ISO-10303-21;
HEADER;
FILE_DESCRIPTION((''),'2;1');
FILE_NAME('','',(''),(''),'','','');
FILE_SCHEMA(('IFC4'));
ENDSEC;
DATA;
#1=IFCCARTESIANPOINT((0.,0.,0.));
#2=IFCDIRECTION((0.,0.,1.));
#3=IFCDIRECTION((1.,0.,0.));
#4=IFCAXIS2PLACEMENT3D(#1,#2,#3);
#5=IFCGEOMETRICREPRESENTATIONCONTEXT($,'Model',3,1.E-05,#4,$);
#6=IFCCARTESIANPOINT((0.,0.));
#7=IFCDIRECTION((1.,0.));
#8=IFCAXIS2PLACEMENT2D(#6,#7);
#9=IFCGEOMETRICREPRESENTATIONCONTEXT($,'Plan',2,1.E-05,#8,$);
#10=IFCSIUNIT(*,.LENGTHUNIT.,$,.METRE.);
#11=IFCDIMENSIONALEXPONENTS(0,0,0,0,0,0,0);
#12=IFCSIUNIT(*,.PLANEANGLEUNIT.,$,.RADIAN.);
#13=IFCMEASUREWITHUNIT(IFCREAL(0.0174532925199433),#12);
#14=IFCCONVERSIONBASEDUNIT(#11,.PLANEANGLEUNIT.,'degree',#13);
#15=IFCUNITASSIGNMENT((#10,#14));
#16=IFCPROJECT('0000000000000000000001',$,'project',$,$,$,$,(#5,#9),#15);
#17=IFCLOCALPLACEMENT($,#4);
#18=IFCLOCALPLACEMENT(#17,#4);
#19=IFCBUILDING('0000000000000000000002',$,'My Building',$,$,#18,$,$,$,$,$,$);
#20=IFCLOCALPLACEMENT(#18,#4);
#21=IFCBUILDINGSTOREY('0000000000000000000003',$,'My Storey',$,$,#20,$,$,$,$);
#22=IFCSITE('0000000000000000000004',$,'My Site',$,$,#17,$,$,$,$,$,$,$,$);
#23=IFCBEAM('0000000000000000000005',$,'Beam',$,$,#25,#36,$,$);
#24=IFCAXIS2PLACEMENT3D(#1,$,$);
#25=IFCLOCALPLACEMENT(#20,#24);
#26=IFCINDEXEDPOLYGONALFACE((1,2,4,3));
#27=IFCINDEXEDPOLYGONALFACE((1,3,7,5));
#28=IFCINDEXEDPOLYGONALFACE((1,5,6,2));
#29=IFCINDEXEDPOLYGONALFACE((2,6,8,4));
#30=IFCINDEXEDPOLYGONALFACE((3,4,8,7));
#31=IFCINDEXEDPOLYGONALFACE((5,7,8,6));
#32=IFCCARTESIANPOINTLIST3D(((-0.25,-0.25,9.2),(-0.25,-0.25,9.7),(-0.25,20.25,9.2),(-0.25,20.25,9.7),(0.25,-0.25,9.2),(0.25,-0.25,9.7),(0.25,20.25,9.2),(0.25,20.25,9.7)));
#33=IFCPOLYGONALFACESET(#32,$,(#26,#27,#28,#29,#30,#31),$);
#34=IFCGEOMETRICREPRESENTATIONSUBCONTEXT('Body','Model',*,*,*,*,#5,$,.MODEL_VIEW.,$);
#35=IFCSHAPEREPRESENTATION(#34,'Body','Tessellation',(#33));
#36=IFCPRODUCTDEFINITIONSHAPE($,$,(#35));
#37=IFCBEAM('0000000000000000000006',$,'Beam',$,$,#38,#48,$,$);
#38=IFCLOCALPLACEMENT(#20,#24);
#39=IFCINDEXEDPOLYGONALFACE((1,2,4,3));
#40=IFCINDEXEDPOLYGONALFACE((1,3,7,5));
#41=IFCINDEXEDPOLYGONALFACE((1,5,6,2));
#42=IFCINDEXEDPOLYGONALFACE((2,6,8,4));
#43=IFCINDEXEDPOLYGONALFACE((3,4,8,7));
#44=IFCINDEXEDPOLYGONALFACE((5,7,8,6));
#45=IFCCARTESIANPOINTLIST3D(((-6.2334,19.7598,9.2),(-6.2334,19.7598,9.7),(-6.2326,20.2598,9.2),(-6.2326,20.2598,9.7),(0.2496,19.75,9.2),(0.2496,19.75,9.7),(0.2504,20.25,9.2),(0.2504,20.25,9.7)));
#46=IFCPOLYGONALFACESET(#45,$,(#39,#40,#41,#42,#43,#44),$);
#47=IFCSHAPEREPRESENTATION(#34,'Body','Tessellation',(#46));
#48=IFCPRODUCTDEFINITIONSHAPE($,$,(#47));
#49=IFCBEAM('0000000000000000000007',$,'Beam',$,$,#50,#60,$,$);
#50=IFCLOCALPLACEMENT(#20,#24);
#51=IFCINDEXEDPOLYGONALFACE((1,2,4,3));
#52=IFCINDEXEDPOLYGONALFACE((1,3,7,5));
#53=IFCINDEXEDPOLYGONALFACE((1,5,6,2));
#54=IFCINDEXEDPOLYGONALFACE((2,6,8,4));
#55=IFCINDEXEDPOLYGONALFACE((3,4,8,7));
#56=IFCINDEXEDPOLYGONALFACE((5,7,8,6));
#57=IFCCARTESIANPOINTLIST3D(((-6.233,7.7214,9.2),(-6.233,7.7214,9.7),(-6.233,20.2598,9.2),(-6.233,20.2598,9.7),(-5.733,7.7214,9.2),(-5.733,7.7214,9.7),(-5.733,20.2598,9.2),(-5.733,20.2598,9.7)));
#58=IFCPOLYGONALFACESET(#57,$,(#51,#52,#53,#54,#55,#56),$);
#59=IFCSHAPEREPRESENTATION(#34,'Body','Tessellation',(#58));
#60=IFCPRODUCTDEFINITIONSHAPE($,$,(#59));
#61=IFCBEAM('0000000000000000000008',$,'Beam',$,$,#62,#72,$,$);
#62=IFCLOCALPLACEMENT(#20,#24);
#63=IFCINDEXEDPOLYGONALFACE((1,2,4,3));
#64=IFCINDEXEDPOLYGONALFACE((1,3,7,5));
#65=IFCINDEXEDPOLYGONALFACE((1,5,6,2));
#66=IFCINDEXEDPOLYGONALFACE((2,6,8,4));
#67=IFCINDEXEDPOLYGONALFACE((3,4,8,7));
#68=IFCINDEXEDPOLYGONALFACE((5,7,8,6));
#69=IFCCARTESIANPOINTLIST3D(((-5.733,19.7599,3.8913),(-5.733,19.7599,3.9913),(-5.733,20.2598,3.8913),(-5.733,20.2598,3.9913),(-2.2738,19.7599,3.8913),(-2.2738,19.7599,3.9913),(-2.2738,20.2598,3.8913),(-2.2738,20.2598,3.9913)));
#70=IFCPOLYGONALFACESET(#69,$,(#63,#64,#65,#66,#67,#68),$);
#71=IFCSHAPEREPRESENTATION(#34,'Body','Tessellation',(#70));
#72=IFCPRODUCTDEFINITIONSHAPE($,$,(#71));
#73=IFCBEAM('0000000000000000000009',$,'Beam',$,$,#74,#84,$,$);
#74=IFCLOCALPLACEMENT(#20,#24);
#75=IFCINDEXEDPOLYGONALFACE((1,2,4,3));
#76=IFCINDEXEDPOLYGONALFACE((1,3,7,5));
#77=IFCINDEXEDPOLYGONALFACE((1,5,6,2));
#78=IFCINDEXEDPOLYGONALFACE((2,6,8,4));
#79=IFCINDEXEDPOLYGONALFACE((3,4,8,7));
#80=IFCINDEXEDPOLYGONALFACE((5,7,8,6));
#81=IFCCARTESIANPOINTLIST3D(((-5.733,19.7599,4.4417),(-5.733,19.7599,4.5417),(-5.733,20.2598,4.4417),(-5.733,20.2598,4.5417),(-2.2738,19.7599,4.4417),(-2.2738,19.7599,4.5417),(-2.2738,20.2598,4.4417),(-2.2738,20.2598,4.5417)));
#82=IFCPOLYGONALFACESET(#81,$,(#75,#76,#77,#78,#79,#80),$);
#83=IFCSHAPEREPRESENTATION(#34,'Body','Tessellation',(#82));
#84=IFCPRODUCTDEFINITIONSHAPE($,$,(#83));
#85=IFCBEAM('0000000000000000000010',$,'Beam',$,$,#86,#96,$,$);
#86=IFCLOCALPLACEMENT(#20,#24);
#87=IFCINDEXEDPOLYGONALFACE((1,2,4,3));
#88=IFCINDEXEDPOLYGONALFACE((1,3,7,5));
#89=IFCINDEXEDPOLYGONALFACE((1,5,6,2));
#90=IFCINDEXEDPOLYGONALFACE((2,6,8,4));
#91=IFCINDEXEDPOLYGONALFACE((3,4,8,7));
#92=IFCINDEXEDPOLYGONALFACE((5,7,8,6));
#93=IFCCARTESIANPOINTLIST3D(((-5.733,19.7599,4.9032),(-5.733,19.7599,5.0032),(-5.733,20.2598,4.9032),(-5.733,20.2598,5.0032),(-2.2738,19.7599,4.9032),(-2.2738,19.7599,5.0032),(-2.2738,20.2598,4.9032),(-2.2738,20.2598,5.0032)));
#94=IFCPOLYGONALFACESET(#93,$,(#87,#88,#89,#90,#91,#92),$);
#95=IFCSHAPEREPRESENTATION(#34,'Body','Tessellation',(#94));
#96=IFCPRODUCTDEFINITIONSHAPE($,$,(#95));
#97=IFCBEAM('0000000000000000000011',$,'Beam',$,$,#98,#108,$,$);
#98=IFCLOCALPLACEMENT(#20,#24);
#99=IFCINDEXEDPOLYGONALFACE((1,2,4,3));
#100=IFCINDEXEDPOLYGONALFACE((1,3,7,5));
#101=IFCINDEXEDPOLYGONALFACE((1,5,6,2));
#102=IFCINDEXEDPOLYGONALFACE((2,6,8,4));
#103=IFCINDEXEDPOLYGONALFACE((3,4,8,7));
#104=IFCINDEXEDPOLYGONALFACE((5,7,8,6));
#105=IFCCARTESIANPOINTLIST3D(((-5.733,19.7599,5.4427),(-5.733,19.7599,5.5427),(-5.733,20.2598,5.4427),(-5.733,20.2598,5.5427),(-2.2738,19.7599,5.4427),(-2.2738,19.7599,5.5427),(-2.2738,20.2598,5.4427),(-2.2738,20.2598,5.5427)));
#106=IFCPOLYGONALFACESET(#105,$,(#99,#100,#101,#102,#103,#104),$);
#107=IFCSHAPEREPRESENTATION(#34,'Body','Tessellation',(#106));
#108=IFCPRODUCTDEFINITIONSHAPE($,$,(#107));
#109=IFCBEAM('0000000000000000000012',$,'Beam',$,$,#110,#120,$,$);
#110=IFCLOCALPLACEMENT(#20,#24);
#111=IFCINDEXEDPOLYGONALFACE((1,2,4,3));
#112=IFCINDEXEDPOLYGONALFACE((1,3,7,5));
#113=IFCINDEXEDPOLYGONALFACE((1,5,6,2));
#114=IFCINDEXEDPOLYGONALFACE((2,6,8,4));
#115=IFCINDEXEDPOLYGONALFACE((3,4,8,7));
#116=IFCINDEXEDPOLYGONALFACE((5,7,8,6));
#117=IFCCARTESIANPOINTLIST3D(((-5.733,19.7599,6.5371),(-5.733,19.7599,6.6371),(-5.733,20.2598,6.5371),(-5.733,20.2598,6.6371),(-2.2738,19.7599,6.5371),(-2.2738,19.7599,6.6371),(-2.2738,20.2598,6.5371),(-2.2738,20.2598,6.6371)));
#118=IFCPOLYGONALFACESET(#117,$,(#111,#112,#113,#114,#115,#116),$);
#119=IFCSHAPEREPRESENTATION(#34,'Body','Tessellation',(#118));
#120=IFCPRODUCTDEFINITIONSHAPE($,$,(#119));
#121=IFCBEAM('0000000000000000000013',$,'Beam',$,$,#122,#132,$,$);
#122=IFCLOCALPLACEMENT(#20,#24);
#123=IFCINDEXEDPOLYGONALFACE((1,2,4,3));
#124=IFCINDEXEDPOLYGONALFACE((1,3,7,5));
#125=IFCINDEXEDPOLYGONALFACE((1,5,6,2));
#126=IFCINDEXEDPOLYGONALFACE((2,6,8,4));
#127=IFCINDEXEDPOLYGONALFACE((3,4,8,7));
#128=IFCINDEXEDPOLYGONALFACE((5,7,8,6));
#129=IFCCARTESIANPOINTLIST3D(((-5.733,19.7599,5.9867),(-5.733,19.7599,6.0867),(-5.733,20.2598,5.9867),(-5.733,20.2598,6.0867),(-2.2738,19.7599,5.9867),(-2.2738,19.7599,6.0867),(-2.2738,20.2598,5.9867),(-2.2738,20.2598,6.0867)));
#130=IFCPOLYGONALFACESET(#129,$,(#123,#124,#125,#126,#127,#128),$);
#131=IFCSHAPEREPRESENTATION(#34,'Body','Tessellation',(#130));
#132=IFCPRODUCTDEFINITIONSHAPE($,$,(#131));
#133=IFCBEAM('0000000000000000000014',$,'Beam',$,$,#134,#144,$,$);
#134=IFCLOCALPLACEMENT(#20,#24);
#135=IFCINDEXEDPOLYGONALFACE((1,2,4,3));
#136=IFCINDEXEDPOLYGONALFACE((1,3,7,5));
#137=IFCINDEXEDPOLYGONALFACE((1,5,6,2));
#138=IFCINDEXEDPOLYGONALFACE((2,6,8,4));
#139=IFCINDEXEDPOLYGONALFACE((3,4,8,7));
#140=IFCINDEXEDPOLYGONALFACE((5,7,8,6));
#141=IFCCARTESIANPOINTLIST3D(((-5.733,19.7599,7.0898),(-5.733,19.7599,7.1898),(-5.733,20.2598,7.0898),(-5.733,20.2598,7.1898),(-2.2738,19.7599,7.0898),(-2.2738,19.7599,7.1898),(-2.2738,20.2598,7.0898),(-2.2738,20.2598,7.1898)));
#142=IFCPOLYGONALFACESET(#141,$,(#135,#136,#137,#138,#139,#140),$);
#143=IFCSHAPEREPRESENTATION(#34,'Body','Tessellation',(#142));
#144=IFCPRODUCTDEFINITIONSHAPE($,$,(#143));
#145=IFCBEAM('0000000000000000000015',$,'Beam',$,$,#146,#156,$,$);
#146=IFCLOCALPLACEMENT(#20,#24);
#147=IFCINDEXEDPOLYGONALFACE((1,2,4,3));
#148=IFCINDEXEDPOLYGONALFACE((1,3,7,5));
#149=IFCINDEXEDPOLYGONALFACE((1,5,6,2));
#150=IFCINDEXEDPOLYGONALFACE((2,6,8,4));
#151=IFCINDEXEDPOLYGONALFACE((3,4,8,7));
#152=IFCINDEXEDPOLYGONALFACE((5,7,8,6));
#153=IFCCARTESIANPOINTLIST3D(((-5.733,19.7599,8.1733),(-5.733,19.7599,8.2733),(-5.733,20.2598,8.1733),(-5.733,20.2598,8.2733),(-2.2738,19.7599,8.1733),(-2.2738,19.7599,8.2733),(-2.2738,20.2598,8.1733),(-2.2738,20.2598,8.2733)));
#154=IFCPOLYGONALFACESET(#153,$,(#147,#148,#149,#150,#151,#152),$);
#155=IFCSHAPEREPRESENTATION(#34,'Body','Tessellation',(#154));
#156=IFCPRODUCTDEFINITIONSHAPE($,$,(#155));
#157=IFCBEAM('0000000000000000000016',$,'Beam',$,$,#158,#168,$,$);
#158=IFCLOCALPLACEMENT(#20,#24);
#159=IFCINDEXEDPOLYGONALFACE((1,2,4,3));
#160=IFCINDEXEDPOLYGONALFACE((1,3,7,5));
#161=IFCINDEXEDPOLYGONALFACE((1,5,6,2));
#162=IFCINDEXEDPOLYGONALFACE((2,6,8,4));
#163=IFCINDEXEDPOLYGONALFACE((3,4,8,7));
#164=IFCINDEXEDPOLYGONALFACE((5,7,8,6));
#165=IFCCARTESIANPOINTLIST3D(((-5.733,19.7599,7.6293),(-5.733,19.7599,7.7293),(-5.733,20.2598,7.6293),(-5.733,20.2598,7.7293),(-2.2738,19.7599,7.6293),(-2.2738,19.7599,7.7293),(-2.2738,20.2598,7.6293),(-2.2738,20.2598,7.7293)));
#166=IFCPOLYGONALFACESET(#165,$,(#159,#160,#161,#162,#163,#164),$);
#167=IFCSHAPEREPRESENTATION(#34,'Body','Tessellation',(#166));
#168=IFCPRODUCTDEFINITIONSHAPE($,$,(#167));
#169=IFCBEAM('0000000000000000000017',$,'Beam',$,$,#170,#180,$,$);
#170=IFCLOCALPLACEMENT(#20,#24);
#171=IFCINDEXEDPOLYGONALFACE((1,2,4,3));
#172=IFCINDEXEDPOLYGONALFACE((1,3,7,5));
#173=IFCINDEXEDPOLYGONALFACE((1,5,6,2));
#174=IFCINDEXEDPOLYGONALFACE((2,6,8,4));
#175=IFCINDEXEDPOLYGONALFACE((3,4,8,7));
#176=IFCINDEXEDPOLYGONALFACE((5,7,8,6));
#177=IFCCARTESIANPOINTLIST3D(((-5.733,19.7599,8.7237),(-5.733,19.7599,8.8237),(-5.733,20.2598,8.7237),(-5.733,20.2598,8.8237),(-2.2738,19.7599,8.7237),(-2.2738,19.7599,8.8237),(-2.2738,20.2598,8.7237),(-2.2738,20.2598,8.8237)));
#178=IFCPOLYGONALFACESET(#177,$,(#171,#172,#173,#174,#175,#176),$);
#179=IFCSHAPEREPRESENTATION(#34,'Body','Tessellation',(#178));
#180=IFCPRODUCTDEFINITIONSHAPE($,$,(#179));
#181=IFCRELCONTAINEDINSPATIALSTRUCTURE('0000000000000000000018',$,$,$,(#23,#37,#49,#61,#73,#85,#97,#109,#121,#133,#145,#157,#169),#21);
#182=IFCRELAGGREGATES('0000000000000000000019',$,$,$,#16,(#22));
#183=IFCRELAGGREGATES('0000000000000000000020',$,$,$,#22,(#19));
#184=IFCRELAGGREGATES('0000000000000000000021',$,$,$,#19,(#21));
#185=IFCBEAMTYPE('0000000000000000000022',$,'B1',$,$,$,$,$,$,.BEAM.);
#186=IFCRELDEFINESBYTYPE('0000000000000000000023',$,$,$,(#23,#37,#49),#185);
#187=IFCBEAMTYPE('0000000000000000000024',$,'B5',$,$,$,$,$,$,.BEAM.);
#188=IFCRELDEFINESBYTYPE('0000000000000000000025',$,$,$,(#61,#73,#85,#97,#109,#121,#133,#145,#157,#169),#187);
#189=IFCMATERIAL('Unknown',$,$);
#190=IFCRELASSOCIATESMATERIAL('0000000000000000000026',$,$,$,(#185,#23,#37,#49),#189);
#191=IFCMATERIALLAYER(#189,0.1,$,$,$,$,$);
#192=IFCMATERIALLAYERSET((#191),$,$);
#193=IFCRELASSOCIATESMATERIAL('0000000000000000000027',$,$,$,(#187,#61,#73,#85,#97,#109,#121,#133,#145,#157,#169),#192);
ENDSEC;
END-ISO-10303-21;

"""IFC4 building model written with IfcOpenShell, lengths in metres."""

from ifc_helpers import new_model, entity, si_unit, converted_unit, frame, origin_with_axes, origin_2d_with_axis, place, context, subcontext, project, spatial, indexed_curve, rectangle, outline, extrude, material, layer, layer_set, layer_usage, material_profile, profile_set, profile_usage, type_object, element, save


model = new_model("IFC4")

# Units and contexts
model_context = context("Model", 3, precision=1e-05, world=origin_with_axes())
plan_context = context("Plan", 2, precision=1e-05, world=origin_2d_with_axis())
body_context = subcontext(model_context, "Body", "Model", "MODEL_VIEW")
ifc_project = project(units=[si_unit("LENGTHUNIT", "METRE"), converted_unit("PLANEANGLEUNIT", "degree", entity("IfcReal", 0.0174532925199433), si_unit("PLANEANGLEUNIT", "RADIAN"), dimensions=[0, 0, 0, 0, 0, 0, 0])], contexts=[model_context, plan_context])

# Site, building, storey
site_placement = place(None, origin_with_axes())
site = spatial("IfcSite", under=ifc_project, at=site_placement, Name="My Site")
building_placement = place(site_placement, origin_with_axes())
building = spatial("IfcBuilding", under=site, at=building_placement, Name="My Building")
storey_placement = place(building_placement, origin_with_axes())
storey = spatial("IfcBuildingStorey", under=building, at=storey_placement, Name="My Storey")

# Beams
ifc_material = material(Name="Unknown")
ifc_material_profile = material_profile(ifc_material, rectangle(XDim=0.5, YDim=0.5))
ifc_profile_set = profile_set([ifc_material_profile])
ifc_profile_usage_1 = profile_usage(ifc_profile_set, cardinal=8)
beam_type_1 = type_object("IfcBeamType", Name="B1", PredefinedType="BEAM", material=ifc_profile_set)
beam_1_placement = place(storey_placement, frame((0.0, 20.25, 9.7), z_axis=(0.0, -1.0, 0.0), x_axis=(1.0, 0.0, 0.0)))
element("IfcBeam", 1, at=beam_1_placement, inside=storey, type_object=beam_type_1, material=ifc_profile_usage_1, Name="Beam", context=body_context, shape_type="SweptSolid", body=[
    extrude(rectangle(XDim=0.5, YDim=0.5), frame((0.0, -0.25, 0.0), z_axis=(0.0, 0.0, 1.0), x_axis=(1.0, 0.0, 0.0)), (0.0, 0.0, 1.0), 20.5),
])
ifc_profile_usage_2 = profile_usage(ifc_profile_set, cardinal=8)
beam_2_placement = place(storey_placement, frame((0.25, 20.0, 9.7), z_axis=(-0.999999, 0.001518, 0.0), x_axis=(-0.001518, -0.999999, 0.0)))
element("IfcBeam", 2, at=beam_2_placement, inside=storey, type_object=beam_type_1, material=ifc_profile_usage_2, Name="Beam", context=body_context, shape_type="SweptSolid", body=[
    extrude(rectangle(XDim=0.5, YDim=0.5), frame((0.0, -0.25, 0.0), z_axis=(0.0, 0.0, 1.0), x_axis=(1.0, 0.0, 0.0)), (0.0, 0.0, 1.0), 6.483),
])
ifc_profile_usage_3 = profile_usage(ifc_profile_set, cardinal=8)
beam_3_placement = place(storey_placement, frame((-5.983, 20.2598, 9.7), z_axis=(0.0, -1.0, 0.0), x_axis=(1.0, 0.0, 0.0)))
element("IfcBeam", 3, at=beam_3_placement, inside=storey, type_object=beam_type_1, material=ifc_profile_usage_3, Name="Beam", context=body_context, shape_type="SweptSolid", body=[
    extrude(rectangle(XDim=0.5, YDim=0.5), frame((0.0, -0.25, 0.0), z_axis=(0.0, 0.0, 1.0), x_axis=(1.0, 0.0, 0.0)), (0.0, 0.0, 1.0), 12.5385),
])
ifc_layer = layer(ifc_material, 0.1)
ifc_layer_set = layer_set([ifc_layer])
beam_type_2 = type_object("IfcBeamType", Name="B5", PredefinedType="BEAM", material=ifc_layer_set)
ifc_layer_usage_1 = layer_usage(ifc_layer_set, "AXIS3", "POSITIVE", -0.1)
beam_4_placement = place(storey_placement, frame((-2.2738, 20.2598, 3.9913), z_axis=(0.0, 0.0, 1.0), x_axis=(1.0, 0.0, 0.0)))
element("IfcBeam", 4, at=beam_4_placement, inside=storey, type_object=beam_type_2, material=ifc_layer_usage_1, Name="Beam", context=body_context, shape_type="SweptSolid", body=[
    extrude(outline(indexed_curve([(0.0, 0.0), (0.0, -0.5), (-3.4592, -0.5), (-3.4592, 0.0), (0.0, 0.0), (0.0, 0.0)])), frame((0.0, 0.0, -0.1), z_axis=(0.0, 0.0, 1.0), x_axis=(1.0, 0.0, 0.0)), (0.0, 0.0, 1.0), 0.1),
])
ifc_layer_usage_2 = layer_usage(ifc_layer_set, "AXIS3", "POSITIVE", -0.1)
beam_5_placement = place(storey_placement, frame((-2.2738, 20.2598, 4.5417), z_axis=(0.0, 0.0, 1.0), x_axis=(1.0, 0.0, 0.0)))
element("IfcBeam", 5, at=beam_5_placement, inside=storey, type_object=beam_type_2, material=ifc_layer_usage_2, Name="Beam", context=body_context, shape_type="SweptSolid", body=[
    extrude(outline(indexed_curve([(0.0, 0.0), (0.0, -0.5), (-3.4592, -0.5), (-3.4592, 0.0), (0.0, 0.0), (0.0, 0.0)])), frame((0.0, 0.0, -0.1), z_axis=(0.0, 0.0, 1.0), x_axis=(1.0, 0.0, 0.0)), (0.0, 0.0, 1.0), 0.1),
])
ifc_layer_usage_3 = layer_usage(ifc_layer_set, "AXIS3", "POSITIVE", -0.1)
beam_6_placement = place(storey_placement, frame((-2.2738, 20.2598, 5.0032), z_axis=(0.0, 0.0, 1.0), x_axis=(1.0, 0.0, 0.0)))
element("IfcBeam", 6, at=beam_6_placement, inside=storey, type_object=beam_type_2, material=ifc_layer_usage_3, Name="Beam", context=body_context, shape_type="SweptSolid", body=[
    extrude(outline(indexed_curve([(0.0, 0.0), (0.0, -0.5), (-3.4592, -0.5), (-3.4592, 0.0), (0.0, 0.0), (0.0, 0.0)])), frame((0.0, 0.0, -0.1), z_axis=(0.0, 0.0, 1.0), x_axis=(1.0, 0.0, 0.0)), (0.0, 0.0, 1.0), 0.1),
])
ifc_layer_usage_4 = layer_usage(ifc_layer_set, "AXIS3", "POSITIVE", -0.1)
beam_7_placement = place(storey_placement, frame((-2.2738, 20.2598, 5.5427), z_axis=(0.0, 0.0, 1.0), x_axis=(1.0, 0.0, 0.0)))
element("IfcBeam", 7, at=beam_7_placement, inside=storey, type_object=beam_type_2, material=ifc_layer_usage_4, Name="Beam", context=body_context, shape_type="SweptSolid", body=[
    extrude(outline(indexed_curve([(0.0, 0.0), (0.0, -0.5), (-3.4592, -0.5), (-3.4592, 0.0), (0.0, 0.0), (0.0, 0.0)])), frame((0.0, 0.0, -0.1), z_axis=(0.0, 0.0, 1.0), x_axis=(1.0, 0.0, 0.0)), (0.0, 0.0, 1.0), 0.1),
])
ifc_layer_usage_5 = layer_usage(ifc_layer_set, "AXIS3", "POSITIVE", -0.1)
beam_8_placement = place(storey_placement, frame((-2.2738, 20.2598, 6.6371), z_axis=(0.0, 0.0, 1.0), x_axis=(1.0, 0.0, 0.0)))
element("IfcBeam", 8, at=beam_8_placement, inside=storey, type_object=beam_type_2, material=ifc_layer_usage_5, Name="Beam", context=body_context, shape_type="SweptSolid", body=[
    extrude(outline(indexed_curve([(0.0, 0.0), (0.0, -0.5), (-3.4592, -0.5), (-3.4592, 0.0), (0.0, 0.0), (0.0, 0.0)])), frame((0.0, 0.0, -0.1), z_axis=(0.0, 0.0, 1.0), x_axis=(1.0, 0.0, 0.0)), (0.0, 0.0, 1.0), 0.1),
])
ifc_layer_usage_6 = layer_usage(ifc_layer_set, "AXIS3", "POSITIVE", -0.1)
beam_9_placement = place(storey_placement, frame((-2.2738, 20.2598, 6.0867), z_axis=(0.0, 0.0, 1.0), x_axis=(1.0, 0.0, 0.0)))
element("IfcBeam", 9, at=beam_9_placement, inside=storey, type_object=beam_type_2, material=ifc_layer_usage_6, Name="Beam", context=body_context, shape_type="SweptSolid", body=[
    extrude(outline(indexed_curve([(0.0, 0.0), (0.0, -0.5), (-3.4592, -0.5), (-3.4592, 0.0), (0.0, 0.0), (0.0, 0.0)])), frame((0.0, 0.0, -0.1), z_axis=(0.0, 0.0, 1.0), x_axis=(1.0, 0.0, 0.0)), (0.0, 0.0, 1.0), 0.1),
])
ifc_layer_usage_7 = layer_usage(ifc_layer_set, "AXIS3", "POSITIVE", -0.1)
beam_10_placement = place(storey_placement, frame((-2.2738, 20.2598, 7.1898), z_axis=(0.0, 0.0, 1.0), x_axis=(1.0, 0.0, 0.0)))
element("IfcBeam", 10, at=beam_10_placement, inside=storey, type_object=beam_type_2, material=ifc_layer_usage_7, Name="Beam", context=body_context, shape_type="SweptSolid", body=[
    extrude(outline(indexed_curve([(0.0, 0.0), (0.0, -0.5), (-3.4592, -0.5), (-3.4592, 0.0), (0.0, 0.0), (0.0, 0.0)])), frame((0.0, 0.0, -0.1), z_axis=(0.0, 0.0, 1.0), x_axis=(1.0, 0.0, 0.0)), (0.0, 0.0, 1.0), 0.1),
])
ifc_layer_usage_8 = layer_usage(ifc_layer_set, "AXIS3", "POSITIVE", -0.1)
beam_11_placement = place(storey_placement, frame((-2.2738, 20.2598, 8.2733), z_axis=(0.0, 0.0, 1.0), x_axis=(1.0, 0.0, 0.0)))
element("IfcBeam", 11, at=beam_11_placement, inside=storey, type_object=beam_type_2, material=ifc_layer_usage_8, Name="Beam", context=body_context, shape_type="SweptSolid", body=[
    extrude(outline(indexed_curve([(0.0, 0.0), (0.0, -0.5), (-3.4592, -0.5), (-3.4592, 0.0), (0.0, 0.0), (0.0, 0.0)])), frame((0.0, 0.0, -0.1), z_axis=(0.0, 0.0, 1.0), x_axis=(1.0, 0.0, 0.0)), (0.0, 0.0, 1.0), 0.1),
])
ifc_layer_usage_9 = layer_usage(ifc_layer_set, "AXIS3", "POSITIVE", -0.1)
beam_12_placement = place(storey_placement, frame((-2.2738, 20.2598, 7.7293), z_axis=(0.0, 0.0, 1.0), x_axis=(1.0, 0.0, 0.0)))
element("IfcBeam", 12, at=beam_12_placement, inside=storey, type_object=beam_type_2, material=ifc_layer_usage_9, Name="Beam", context=body_context, shape_type="SweptSolid", body=[
    extrude(outline(indexed_curve([(0.0, 0.0), (0.0, -0.5), (-3.4592, -0.5), (-3.4592, 0.0), (0.0, 0.0), (0.0, 0.0)])), frame((0.0, 0.0, -0.1), z_axis=(0.0, 0.0, 1.0), x_axis=(1.0, 0.0, 0.0)), (0.0, 0.0, 1.0), 0.1),
])
ifc_layer_usage_10 = layer_usage(ifc_layer_set, "AXIS3", "POSITIVE", -0.1)
beam_13_placement = place(storey_placement, frame((-2.2738, 20.2598, 8.8237), z_axis=(0.0, 0.0, 1.0), x_axis=(1.0, 0.0, 0.0)))
element("IfcBeam", 13, at=beam_13_placement, inside=storey, type_object=beam_type_2, material=ifc_layer_usage_10, Name="Beam", context=body_context, shape_type="SweptSolid", body=[
    extrude(outline(indexed_curve([(0.0, 0.0), (0.0, -0.5), (-3.4592, -0.5), (-3.4592, 0.0), (0.0, 0.0), (0.0, 0.0)])), frame((0.0, 0.0, -0.1), z_axis=(0.0, 0.0, 1.0), x_axis=(1.0, 0.0, 0.0)), (0.0, 0.0, 1.0), 0.1),
])

save(model, "model.ifc")
